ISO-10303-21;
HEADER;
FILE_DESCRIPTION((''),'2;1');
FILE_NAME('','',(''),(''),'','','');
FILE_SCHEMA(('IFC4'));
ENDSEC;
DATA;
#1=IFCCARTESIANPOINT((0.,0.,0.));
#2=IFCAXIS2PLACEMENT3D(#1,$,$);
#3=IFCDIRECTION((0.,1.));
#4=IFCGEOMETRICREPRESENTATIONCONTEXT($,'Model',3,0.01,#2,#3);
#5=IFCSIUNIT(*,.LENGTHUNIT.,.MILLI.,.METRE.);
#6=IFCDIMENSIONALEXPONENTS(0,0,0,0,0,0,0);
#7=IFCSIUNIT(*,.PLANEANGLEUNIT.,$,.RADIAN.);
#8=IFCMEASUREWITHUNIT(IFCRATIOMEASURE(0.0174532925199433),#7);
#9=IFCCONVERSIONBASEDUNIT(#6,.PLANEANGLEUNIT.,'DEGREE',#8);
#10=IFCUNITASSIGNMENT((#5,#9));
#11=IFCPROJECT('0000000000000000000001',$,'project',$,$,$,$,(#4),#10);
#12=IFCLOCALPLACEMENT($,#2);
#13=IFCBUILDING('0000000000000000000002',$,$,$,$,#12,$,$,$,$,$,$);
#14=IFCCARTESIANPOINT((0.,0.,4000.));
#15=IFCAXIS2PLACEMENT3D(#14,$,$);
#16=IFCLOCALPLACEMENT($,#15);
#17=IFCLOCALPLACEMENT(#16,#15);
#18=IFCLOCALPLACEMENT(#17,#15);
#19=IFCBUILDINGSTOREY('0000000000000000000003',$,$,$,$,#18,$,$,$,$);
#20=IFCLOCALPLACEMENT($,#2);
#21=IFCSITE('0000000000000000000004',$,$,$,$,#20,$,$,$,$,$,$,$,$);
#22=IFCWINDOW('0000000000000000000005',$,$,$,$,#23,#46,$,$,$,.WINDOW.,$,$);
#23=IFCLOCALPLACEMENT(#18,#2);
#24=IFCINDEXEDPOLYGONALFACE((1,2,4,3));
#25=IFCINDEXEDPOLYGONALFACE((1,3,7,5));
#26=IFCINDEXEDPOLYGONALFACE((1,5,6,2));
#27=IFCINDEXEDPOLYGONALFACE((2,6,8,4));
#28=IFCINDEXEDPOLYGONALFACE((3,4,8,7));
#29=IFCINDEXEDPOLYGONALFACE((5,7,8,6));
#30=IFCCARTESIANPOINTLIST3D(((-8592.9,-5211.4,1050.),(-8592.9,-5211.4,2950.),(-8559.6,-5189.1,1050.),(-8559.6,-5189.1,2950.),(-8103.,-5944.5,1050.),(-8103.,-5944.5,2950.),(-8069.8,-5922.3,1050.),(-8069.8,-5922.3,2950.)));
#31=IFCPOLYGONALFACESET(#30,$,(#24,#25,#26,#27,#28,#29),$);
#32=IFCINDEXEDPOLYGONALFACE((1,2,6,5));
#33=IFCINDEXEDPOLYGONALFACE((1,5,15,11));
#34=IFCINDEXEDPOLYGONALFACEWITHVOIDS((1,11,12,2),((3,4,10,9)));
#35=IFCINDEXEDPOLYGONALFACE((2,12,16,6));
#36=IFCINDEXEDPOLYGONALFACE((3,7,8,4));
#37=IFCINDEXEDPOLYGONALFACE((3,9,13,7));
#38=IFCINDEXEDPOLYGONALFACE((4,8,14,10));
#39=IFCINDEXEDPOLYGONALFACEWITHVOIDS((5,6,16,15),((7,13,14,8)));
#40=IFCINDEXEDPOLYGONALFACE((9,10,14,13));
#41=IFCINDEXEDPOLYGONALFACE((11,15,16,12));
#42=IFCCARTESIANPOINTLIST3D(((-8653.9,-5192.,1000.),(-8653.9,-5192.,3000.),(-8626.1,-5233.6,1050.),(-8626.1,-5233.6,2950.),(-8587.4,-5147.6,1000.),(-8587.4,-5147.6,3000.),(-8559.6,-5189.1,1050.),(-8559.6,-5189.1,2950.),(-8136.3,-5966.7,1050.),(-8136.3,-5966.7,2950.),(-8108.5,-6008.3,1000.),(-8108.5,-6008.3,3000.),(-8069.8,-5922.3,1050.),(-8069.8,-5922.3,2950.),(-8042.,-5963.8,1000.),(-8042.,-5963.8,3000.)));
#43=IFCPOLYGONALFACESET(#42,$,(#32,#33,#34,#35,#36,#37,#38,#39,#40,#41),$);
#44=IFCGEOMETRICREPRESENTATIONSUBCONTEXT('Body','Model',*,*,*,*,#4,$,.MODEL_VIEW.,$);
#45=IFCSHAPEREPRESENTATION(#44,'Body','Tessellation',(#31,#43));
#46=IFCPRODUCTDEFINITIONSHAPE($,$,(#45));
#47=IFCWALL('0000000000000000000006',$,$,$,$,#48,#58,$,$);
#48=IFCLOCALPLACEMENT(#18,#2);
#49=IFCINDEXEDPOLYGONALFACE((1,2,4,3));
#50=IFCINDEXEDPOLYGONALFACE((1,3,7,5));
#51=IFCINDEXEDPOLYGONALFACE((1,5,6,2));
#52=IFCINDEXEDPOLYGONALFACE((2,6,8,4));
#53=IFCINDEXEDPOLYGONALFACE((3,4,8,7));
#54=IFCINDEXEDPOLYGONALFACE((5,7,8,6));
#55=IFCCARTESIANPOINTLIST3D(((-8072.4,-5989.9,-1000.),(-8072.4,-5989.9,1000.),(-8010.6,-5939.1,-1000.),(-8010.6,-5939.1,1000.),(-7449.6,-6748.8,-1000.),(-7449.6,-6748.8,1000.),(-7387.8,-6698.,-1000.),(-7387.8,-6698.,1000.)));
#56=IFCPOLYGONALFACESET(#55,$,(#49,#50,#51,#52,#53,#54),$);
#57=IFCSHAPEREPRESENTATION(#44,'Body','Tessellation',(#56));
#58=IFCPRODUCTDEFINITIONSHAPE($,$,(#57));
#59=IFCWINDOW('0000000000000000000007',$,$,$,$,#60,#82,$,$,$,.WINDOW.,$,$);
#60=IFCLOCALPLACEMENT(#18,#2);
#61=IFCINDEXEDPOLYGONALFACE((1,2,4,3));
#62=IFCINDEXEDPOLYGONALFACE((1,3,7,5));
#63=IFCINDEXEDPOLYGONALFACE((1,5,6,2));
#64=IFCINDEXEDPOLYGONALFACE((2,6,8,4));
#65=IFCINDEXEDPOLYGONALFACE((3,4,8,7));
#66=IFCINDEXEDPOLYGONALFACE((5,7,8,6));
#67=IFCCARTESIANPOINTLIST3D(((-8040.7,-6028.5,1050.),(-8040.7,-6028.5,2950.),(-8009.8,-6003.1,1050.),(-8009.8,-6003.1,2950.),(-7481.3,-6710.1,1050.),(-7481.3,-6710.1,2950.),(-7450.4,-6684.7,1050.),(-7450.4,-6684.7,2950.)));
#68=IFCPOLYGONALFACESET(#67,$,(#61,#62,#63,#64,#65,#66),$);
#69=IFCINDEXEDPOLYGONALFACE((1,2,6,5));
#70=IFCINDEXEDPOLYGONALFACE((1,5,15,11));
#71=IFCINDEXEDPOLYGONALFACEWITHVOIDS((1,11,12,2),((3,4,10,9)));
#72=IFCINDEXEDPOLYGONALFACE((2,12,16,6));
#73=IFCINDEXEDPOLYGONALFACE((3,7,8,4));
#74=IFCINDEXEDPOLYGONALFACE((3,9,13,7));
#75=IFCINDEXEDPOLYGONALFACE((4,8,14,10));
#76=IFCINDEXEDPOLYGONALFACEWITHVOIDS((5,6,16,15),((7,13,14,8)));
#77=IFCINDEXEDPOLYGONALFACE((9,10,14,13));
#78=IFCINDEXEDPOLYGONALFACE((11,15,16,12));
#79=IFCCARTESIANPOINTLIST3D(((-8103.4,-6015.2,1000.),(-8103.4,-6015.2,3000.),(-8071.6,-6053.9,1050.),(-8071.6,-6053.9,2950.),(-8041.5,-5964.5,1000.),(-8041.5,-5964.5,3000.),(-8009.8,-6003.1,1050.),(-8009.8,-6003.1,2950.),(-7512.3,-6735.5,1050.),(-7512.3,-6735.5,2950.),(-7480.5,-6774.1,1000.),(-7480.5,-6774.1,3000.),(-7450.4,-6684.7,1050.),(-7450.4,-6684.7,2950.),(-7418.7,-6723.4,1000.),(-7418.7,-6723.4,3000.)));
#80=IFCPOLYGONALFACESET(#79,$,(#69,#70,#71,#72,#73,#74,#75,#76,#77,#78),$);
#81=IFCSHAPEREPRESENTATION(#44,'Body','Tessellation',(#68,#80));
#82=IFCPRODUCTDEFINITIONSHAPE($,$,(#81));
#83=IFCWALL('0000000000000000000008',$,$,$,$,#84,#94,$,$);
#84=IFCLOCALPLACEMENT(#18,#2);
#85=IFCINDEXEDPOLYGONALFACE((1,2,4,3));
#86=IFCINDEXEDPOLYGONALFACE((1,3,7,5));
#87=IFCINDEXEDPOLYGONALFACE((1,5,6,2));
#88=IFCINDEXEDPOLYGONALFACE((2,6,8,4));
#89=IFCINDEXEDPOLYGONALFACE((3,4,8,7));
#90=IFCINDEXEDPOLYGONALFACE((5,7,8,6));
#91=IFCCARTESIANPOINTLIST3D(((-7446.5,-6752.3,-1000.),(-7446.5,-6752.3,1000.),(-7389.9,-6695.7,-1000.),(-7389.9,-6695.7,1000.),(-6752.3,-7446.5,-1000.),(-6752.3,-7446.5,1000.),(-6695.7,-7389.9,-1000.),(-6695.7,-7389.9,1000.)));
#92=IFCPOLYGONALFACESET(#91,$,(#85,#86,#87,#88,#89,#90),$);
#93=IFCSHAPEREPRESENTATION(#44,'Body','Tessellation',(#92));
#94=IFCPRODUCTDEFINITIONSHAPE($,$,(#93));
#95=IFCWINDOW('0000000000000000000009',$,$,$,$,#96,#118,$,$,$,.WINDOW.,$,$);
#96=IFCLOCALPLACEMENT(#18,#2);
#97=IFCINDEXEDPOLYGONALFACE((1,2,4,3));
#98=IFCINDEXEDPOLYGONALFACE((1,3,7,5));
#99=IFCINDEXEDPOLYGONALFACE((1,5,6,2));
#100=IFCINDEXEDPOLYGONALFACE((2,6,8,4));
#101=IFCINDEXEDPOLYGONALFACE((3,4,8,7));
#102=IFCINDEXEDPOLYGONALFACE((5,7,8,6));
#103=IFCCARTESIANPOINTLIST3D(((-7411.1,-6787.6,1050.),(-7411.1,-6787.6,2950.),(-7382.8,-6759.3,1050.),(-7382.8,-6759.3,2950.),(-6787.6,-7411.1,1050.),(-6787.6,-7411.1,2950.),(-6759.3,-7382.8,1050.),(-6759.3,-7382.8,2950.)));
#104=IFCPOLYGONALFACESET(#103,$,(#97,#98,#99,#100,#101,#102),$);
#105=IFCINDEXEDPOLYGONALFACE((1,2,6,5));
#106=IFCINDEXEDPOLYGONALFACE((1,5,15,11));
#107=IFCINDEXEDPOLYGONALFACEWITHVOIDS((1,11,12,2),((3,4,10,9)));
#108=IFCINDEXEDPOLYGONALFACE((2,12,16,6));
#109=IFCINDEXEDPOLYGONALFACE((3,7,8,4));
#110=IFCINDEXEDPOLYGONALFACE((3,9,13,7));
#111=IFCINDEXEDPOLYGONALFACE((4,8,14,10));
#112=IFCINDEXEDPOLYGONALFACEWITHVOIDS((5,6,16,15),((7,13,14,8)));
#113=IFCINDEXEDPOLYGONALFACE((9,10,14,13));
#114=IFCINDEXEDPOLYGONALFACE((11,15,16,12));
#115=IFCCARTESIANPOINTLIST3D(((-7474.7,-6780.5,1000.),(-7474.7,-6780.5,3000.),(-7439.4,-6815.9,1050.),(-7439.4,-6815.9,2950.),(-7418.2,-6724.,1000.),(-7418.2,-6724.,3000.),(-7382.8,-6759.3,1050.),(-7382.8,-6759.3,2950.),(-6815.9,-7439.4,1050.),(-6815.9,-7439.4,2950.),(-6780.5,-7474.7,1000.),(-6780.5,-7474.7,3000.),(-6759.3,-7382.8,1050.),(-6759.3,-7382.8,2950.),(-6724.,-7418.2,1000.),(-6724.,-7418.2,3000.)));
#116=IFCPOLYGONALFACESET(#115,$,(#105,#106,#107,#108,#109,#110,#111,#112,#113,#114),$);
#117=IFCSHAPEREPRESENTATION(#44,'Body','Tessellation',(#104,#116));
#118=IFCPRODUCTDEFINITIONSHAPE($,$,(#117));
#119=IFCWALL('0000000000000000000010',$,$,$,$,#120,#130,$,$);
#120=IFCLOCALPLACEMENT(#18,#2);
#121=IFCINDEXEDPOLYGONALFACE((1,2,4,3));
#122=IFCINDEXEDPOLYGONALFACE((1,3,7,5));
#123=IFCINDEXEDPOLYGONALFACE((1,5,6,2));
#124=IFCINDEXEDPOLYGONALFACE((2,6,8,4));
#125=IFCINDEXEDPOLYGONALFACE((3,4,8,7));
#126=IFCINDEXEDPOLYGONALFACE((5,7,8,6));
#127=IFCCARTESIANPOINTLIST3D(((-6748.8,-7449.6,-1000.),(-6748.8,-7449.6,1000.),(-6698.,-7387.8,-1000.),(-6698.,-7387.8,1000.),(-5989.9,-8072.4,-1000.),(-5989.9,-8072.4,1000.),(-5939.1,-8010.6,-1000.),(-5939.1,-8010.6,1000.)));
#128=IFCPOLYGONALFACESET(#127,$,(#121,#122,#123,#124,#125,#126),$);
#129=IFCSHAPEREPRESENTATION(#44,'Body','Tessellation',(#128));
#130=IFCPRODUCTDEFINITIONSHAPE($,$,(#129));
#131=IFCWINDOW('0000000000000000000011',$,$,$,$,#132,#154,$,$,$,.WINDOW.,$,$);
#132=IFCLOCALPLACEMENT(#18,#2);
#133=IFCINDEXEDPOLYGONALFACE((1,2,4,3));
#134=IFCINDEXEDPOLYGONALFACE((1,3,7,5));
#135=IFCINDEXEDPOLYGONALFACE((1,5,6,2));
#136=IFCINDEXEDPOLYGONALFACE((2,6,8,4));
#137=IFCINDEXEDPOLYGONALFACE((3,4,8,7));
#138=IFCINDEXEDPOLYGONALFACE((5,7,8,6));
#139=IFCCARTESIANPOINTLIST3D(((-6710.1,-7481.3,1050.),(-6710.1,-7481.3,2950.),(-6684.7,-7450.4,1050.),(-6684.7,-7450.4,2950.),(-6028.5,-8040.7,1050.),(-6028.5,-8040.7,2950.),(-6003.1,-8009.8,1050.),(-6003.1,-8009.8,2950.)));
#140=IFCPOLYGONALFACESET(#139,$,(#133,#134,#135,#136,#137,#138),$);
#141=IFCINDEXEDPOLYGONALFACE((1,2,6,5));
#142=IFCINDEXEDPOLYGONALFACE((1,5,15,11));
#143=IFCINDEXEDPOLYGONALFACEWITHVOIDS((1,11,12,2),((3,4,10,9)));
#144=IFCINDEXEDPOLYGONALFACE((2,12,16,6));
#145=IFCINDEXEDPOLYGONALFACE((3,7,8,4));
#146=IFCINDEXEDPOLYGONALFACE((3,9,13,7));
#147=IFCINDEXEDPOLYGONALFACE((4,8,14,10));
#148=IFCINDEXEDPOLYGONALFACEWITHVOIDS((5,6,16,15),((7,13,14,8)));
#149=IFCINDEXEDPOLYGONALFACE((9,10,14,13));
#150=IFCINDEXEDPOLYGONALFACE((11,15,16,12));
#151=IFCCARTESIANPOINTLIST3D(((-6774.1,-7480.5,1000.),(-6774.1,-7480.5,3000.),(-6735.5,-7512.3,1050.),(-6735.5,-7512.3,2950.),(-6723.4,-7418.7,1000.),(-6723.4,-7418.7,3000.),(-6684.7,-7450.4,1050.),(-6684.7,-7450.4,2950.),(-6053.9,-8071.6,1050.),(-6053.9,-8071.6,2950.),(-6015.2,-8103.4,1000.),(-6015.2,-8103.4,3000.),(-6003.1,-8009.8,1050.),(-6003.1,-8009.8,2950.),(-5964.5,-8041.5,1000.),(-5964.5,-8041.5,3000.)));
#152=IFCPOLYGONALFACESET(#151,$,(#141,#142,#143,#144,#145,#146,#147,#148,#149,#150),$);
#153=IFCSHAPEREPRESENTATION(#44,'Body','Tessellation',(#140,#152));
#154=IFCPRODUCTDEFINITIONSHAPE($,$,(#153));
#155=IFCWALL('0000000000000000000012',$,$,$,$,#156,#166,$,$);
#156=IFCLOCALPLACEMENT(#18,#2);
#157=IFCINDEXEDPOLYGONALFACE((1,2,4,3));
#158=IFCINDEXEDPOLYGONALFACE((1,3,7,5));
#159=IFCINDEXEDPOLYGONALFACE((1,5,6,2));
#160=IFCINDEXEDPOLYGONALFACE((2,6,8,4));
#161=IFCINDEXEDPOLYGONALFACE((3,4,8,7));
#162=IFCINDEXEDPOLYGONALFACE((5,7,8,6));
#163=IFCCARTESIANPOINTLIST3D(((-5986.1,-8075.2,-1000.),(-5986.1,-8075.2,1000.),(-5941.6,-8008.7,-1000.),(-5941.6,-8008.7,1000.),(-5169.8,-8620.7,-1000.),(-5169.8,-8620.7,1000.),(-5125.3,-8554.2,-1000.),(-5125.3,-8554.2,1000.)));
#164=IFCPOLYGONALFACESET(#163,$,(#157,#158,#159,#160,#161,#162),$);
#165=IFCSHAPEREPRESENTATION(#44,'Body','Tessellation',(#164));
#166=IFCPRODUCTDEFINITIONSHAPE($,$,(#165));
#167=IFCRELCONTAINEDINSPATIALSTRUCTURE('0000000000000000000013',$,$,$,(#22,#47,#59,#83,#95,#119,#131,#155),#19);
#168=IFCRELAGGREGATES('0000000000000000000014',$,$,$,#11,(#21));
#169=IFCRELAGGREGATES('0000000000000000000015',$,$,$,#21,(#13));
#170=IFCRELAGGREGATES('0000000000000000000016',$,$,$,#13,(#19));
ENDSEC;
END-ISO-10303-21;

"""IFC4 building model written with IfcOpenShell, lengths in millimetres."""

from ifc_helpers import new_model, entity, si_unit, converted_unit, direction, frame, origin, origin_2d, place, context, subcontext, project, spatial, rectangle, extrude, element, save


model = new_model("IFC4")

# Units and contexts
model_context = context("Model", 3, precision=0.01, world=origin(), true_north=direction((0.0, 1.0)))
body_context = subcontext(model_context, "Body", "Model", "MODEL_VIEW")
ifc_project = project(units=[si_unit("LENGTHUNIT", "METRE", prefix="MILLI"), converted_unit("PLANEANGLEUNIT", "DEGREE", entity("IfcRatioMeasure", 0.0174532925199433), si_unit("PLANEANGLEUNIT", "RADIAN"), dimensions=[0, 0, 0, 0, 0, 0, 0])], contexts=[model_context])

# Site, building, storey
site_placement = place(None, origin())
site = spatial("IfcSite", under=ifc_project, at=site_placement)
building_placement = place(None, origin())
building = spatial("IfcBuilding", under=site, at=building_placement)
placement_1 = place(None, frame((0.0, 0.0, 4000.0)))
placement_2 = place(placement_1, frame((0.0, 0.0, 4000.0)))
storey_placement = place(placement_2, frame((0.0, 0.0, 4000.0)))
storey = spatial("IfcBuildingStorey", under=building, at=storey_placement)

# Shared definitions
cartesian_point_1 = entity("IfcCartesianPoint", [-440.9, -950.0])
shared_polyline = entity("IfcPolyline", [cartesian_point_1, entity("IfcCartesianPoint", [-440.9, 950.0]), entity("IfcCartesianPoint", [-440.9, 950.0]), entity("IfcCartesianPoint", [440.9, 950.0]), entity("IfcCartesianPoint", [440.9, 950.0]), entity("IfcCartesianPoint", [440.9, -950.0]), entity("IfcCartesianPoint", [440.9, -950.0]), entity("IfcCartesianPoint", [-440.9, -950.0]), cartesian_point_1])

# Window
window_1_placement = place(storey_placement, frame((-8314.7, -5555.7, 2000.0), z_axis=(0.0, 0.0, 1.0), x_axis=(5555.703069, -8314.695629, 0.0)))
cartesian_point_2 = entity("IfcCartesianPoint", [-490.9, -1000.0])
element("IfcWindow", 1, at=window_1_placement, inside=storey, PredefinedType="WINDOW", context=body_context, shape_type="SweptSolid", body=[
    entity("IfcExtrudedAreaSolid", entity("IfcArbitraryClosedProfileDef", "AREA", None, shared_polyline), entity("IfcAxis2Placement3D", entity("IfcCartesianPoint", [0.0, 0.0, 0.0]), entity("IfcDirection", [0.0, -1.0, 0.0]), entity("IfcDirection", [1.0, 0.0, 0.0])), entity("IfcDirection", [0.0, 0.0, 1.0]), 40.0),
    entity("IfcExtrudedAreaSolid", entity("IfcArbitraryProfileDefWithVoids", "AREA", None, entity("IfcPolyline", [cartesian_point_2, entity("IfcCartesianPoint", [-490.9, 1000.0]), entity("IfcCartesianPoint", [-490.9, 1000.0]), entity("IfcCartesianPoint", [490.9, 1000.0]), entity("IfcCartesianPoint", [490.9, 1000.0]), entity("IfcCartesianPoint", [490.9, -1000.0]), entity("IfcCartesianPoint", [490.9, -1000.0]), entity("IfcCartesianPoint", [-490.9, -1000.0]), cartesian_point_2]), [shared_polyline]), entity("IfcAxis2Placement3D", entity("IfcCartesianPoint", [0.0, 0.0, 0.0]), entity("IfcDirection", [0.0, -1.0, 0.0]), entity("IfcDirection", [1.0, 0.0, 0.0])), entity("IfcDirection", [0.0, 0.0, 1.0]), 80.0),
])

# Wall
wall_1_placement = place(storey_placement, frame((-7730.1, -6343.9, -1000.0), z_axis=(0.0, 0.0, 1.0), x_axis=(6343.931995, -7730.105228, 0.0)))
element("IfcWall", 2, at=wall_1_placement, inside=storey, context=body_context, shape_type="SweptSolid", body=[
    extrude(rectangle(XDim=981.7, YDim=80.0, at=origin_2d()), origin(), (0.0, 0.0, 1.0), 2000.0),
])

# Window
window_2_placement = place(storey_placement, frame((-7730.1, -6343.9, 2000.0), z_axis=(0.0, 0.0, 1.0), x_axis=(6343.931995, -7730.105228, 0.0)))
cartesian_point_3 = entity("IfcCartesianPoint", [-490.9, -1000.0])
element("IfcWindow", 3, at=window_2_placement, inside=storey, PredefinedType="WINDOW", context=body_context, shape_type="SweptSolid", body=[
    entity("IfcExtrudedAreaSolid", entity("IfcArbitraryClosedProfileDef", "AREA", None, shared_polyline), entity("IfcAxis2Placement3D", entity("IfcCartesianPoint", [0.0, 0.0, 0.0]), entity("IfcDirection", [0.0, -1.0, 0.0]), entity("IfcDirection", [1.0, 0.0, 0.0])), entity("IfcDirection", [0.0, 0.0, 1.0]), 40.0),
    entity("IfcExtrudedAreaSolid", entity("IfcArbitraryProfileDefWithVoids", "AREA", None, entity("IfcPolyline", [cartesian_point_3, entity("IfcCartesianPoint", [-490.9, 1000.0]), entity("IfcCartesianPoint", [-490.9, 1000.0]), entity("IfcCartesianPoint", [490.9, 1000.0]), entity("IfcCartesianPoint", [490.9, 1000.0]), entity("IfcCartesianPoint", [490.9, -1000.0]), entity("IfcCartesianPoint", [490.9, -1000.0]), entity("IfcCartesianPoint", [-490.9, -1000.0]), cartesian_point_3]), [shared_polyline]), entity("IfcAxis2Placement3D", entity("IfcCartesianPoint", [0.0, 0.0, 0.0]), entity("IfcDirection", [0.0, -1.0, 0.0]), entity("IfcDirection", [1.0, 0.0, 0.0])), entity("IfcDirection", [0.0, 0.0, 1.0]), 80.0),
])

# Wall
wall_2_placement = place(storey_placement, frame((-7071.1, -7071.1, -1000.0), z_axis=(0.0, 0.0, 1.0), x_axis=(7071.06732, -7071.068304, 0.0)))
element("IfcWall", 4, at=wall_2_placement, inside=storey, context=body_context, shape_type="SweptSolid", body=[
    extrude(rectangle(XDim=981.7, YDim=80.0, at=origin_2d()), origin(), (0.0, 0.0, 1.0), 2000.0),
])

# Window
window_3_placement = place(storey_placement, frame((-7071.1, -7071.1, 2000.0), z_axis=(0.0, 0.0, 1.0), x_axis=(7071.06732, -7071.068304, 0.0)))
cartesian_point_4 = entity("IfcCartesianPoint", [-490.9, -1000.0])
element("IfcWindow", 5, at=window_3_placement, inside=storey, PredefinedType="WINDOW", context=body_context, shape_type="SweptSolid", body=[
    entity("IfcExtrudedAreaSolid", entity("IfcArbitraryClosedProfileDef", "AREA", None, shared_polyline), entity("IfcAxis2Placement3D", entity("IfcCartesianPoint", [0.0, 0.0, 0.0]), entity("IfcDirection", [0.0, -1.0, 0.0]), entity("IfcDirection", [1.0, 0.0, 0.0])), entity("IfcDirection", [0.0, 0.0, 1.0]), 40.0),
    entity("IfcExtrudedAreaSolid", entity("IfcArbitraryProfileDefWithVoids", "AREA", None, entity("IfcPolyline", [cartesian_point_4, entity("IfcCartesianPoint", [-490.9, 1000.0]), entity("IfcCartesianPoint", [-490.9, 1000.0]), entity("IfcCartesianPoint", [490.9, 1000.0]), entity("IfcCartesianPoint", [490.9, 1000.0]), entity("IfcCartesianPoint", [490.9, -1000.0]), entity("IfcCartesianPoint", [490.9, -1000.0]), entity("IfcCartesianPoint", [-490.9, -1000.0]), cartesian_point_4]), [shared_polyline]), entity("IfcAxis2Placement3D", entity("IfcCartesianPoint", [0.0, 0.0, 0.0]), entity("IfcDirection", [0.0, -1.0, 0.0]), entity("IfcDirection", [1.0, 0.0, 0.0])), entity("IfcDirection", [0.0, 0.0, 1.0]), 80.0),
])

# Wall
wall_3_placement = place(storey_placement, frame((-6343.9, -7730.1, -1000.0), z_axis=(0.0, 0.0, 1.0), x_axis=(7730.104346, -6343.93307, 0.0)))
element("IfcWall", 6, at=wall_3_placement, inside=storey, context=body_context, shape_type="SweptSolid", body=[
    extrude(rectangle(XDim=981.7, YDim=80.0, at=origin_2d()), origin(), (0.0, 0.0, 1.0), 2000.0),
])

# Window
window_4_placement = place(storey_placement, frame((-6343.9, -7730.1, 2000.0), z_axis=(0.0, 0.0, 1.0), x_axis=(7730.104346, -6343.93307, 0.0)))
cartesian_point_5 = entity("IfcCartesianPoint", [-490.9, -1000.0])
element("IfcWindow", 7, at=window_4_placement, inside=storey, PredefinedType="WINDOW", context=body_context, shape_type="SweptSolid", body=[
    entity("IfcExtrudedAreaSolid", entity("IfcArbitraryClosedProfileDef", "AREA", None, shared_polyline), entity("IfcAxis2Placement3D", entity("IfcCartesianPoint", [0.0, 0.0, 0.0]), entity("IfcDirection", [0.0, -1.0, 0.0]), entity("IfcDirection", [1.0, 0.0, 0.0])), entity("IfcDirection", [0.0, 0.0, 1.0]), 40.0),
    entity("IfcExtrudedAreaSolid", entity("IfcArbitraryProfileDefWithVoids", "AREA", None, entity("IfcPolyline", [cartesian_point_5, entity("IfcCartesianPoint", [-490.9, 1000.0]), entity("IfcCartesianPoint", [-490.9, 1000.0]), entity("IfcCartesianPoint", [490.9, 1000.0]), entity("IfcCartesianPoint", [490.9, 1000.0]), entity("IfcCartesianPoint", [490.9, -1000.0]), entity("IfcCartesianPoint", [490.9, -1000.0]), entity("IfcCartesianPoint", [-490.9, -1000.0]), cartesian_point_5]), [shared_polyline]), entity("IfcAxis2Placement3D", entity("IfcCartesianPoint", [0.0, 0.0, 0.0]), entity("IfcDirection", [0.0, -1.0, 0.0]), entity("IfcDirection", [1.0, 0.0, 0.0])), entity("IfcDirection", [0.0, 0.0, 1.0]), 80.0),
])

# Wall
wall_4_placement = place(storey_placement, frame((-5555.7, -8314.7, -1000.0), z_axis=(0.0, 0.0, 1.0), x_axis=(8314.694856, -5555.704226, 0.0)))
element("IfcWall", 8, at=wall_4_placement, inside=storey, context=body_context, shape_type="SweptSolid", body=[
    extrude(rectangle(XDim=981.7, YDim=80.0, at=origin_2d()), origin(), (0.0, 0.0, 1.0), 2000.0),
])

save(model, "model.ifc")
